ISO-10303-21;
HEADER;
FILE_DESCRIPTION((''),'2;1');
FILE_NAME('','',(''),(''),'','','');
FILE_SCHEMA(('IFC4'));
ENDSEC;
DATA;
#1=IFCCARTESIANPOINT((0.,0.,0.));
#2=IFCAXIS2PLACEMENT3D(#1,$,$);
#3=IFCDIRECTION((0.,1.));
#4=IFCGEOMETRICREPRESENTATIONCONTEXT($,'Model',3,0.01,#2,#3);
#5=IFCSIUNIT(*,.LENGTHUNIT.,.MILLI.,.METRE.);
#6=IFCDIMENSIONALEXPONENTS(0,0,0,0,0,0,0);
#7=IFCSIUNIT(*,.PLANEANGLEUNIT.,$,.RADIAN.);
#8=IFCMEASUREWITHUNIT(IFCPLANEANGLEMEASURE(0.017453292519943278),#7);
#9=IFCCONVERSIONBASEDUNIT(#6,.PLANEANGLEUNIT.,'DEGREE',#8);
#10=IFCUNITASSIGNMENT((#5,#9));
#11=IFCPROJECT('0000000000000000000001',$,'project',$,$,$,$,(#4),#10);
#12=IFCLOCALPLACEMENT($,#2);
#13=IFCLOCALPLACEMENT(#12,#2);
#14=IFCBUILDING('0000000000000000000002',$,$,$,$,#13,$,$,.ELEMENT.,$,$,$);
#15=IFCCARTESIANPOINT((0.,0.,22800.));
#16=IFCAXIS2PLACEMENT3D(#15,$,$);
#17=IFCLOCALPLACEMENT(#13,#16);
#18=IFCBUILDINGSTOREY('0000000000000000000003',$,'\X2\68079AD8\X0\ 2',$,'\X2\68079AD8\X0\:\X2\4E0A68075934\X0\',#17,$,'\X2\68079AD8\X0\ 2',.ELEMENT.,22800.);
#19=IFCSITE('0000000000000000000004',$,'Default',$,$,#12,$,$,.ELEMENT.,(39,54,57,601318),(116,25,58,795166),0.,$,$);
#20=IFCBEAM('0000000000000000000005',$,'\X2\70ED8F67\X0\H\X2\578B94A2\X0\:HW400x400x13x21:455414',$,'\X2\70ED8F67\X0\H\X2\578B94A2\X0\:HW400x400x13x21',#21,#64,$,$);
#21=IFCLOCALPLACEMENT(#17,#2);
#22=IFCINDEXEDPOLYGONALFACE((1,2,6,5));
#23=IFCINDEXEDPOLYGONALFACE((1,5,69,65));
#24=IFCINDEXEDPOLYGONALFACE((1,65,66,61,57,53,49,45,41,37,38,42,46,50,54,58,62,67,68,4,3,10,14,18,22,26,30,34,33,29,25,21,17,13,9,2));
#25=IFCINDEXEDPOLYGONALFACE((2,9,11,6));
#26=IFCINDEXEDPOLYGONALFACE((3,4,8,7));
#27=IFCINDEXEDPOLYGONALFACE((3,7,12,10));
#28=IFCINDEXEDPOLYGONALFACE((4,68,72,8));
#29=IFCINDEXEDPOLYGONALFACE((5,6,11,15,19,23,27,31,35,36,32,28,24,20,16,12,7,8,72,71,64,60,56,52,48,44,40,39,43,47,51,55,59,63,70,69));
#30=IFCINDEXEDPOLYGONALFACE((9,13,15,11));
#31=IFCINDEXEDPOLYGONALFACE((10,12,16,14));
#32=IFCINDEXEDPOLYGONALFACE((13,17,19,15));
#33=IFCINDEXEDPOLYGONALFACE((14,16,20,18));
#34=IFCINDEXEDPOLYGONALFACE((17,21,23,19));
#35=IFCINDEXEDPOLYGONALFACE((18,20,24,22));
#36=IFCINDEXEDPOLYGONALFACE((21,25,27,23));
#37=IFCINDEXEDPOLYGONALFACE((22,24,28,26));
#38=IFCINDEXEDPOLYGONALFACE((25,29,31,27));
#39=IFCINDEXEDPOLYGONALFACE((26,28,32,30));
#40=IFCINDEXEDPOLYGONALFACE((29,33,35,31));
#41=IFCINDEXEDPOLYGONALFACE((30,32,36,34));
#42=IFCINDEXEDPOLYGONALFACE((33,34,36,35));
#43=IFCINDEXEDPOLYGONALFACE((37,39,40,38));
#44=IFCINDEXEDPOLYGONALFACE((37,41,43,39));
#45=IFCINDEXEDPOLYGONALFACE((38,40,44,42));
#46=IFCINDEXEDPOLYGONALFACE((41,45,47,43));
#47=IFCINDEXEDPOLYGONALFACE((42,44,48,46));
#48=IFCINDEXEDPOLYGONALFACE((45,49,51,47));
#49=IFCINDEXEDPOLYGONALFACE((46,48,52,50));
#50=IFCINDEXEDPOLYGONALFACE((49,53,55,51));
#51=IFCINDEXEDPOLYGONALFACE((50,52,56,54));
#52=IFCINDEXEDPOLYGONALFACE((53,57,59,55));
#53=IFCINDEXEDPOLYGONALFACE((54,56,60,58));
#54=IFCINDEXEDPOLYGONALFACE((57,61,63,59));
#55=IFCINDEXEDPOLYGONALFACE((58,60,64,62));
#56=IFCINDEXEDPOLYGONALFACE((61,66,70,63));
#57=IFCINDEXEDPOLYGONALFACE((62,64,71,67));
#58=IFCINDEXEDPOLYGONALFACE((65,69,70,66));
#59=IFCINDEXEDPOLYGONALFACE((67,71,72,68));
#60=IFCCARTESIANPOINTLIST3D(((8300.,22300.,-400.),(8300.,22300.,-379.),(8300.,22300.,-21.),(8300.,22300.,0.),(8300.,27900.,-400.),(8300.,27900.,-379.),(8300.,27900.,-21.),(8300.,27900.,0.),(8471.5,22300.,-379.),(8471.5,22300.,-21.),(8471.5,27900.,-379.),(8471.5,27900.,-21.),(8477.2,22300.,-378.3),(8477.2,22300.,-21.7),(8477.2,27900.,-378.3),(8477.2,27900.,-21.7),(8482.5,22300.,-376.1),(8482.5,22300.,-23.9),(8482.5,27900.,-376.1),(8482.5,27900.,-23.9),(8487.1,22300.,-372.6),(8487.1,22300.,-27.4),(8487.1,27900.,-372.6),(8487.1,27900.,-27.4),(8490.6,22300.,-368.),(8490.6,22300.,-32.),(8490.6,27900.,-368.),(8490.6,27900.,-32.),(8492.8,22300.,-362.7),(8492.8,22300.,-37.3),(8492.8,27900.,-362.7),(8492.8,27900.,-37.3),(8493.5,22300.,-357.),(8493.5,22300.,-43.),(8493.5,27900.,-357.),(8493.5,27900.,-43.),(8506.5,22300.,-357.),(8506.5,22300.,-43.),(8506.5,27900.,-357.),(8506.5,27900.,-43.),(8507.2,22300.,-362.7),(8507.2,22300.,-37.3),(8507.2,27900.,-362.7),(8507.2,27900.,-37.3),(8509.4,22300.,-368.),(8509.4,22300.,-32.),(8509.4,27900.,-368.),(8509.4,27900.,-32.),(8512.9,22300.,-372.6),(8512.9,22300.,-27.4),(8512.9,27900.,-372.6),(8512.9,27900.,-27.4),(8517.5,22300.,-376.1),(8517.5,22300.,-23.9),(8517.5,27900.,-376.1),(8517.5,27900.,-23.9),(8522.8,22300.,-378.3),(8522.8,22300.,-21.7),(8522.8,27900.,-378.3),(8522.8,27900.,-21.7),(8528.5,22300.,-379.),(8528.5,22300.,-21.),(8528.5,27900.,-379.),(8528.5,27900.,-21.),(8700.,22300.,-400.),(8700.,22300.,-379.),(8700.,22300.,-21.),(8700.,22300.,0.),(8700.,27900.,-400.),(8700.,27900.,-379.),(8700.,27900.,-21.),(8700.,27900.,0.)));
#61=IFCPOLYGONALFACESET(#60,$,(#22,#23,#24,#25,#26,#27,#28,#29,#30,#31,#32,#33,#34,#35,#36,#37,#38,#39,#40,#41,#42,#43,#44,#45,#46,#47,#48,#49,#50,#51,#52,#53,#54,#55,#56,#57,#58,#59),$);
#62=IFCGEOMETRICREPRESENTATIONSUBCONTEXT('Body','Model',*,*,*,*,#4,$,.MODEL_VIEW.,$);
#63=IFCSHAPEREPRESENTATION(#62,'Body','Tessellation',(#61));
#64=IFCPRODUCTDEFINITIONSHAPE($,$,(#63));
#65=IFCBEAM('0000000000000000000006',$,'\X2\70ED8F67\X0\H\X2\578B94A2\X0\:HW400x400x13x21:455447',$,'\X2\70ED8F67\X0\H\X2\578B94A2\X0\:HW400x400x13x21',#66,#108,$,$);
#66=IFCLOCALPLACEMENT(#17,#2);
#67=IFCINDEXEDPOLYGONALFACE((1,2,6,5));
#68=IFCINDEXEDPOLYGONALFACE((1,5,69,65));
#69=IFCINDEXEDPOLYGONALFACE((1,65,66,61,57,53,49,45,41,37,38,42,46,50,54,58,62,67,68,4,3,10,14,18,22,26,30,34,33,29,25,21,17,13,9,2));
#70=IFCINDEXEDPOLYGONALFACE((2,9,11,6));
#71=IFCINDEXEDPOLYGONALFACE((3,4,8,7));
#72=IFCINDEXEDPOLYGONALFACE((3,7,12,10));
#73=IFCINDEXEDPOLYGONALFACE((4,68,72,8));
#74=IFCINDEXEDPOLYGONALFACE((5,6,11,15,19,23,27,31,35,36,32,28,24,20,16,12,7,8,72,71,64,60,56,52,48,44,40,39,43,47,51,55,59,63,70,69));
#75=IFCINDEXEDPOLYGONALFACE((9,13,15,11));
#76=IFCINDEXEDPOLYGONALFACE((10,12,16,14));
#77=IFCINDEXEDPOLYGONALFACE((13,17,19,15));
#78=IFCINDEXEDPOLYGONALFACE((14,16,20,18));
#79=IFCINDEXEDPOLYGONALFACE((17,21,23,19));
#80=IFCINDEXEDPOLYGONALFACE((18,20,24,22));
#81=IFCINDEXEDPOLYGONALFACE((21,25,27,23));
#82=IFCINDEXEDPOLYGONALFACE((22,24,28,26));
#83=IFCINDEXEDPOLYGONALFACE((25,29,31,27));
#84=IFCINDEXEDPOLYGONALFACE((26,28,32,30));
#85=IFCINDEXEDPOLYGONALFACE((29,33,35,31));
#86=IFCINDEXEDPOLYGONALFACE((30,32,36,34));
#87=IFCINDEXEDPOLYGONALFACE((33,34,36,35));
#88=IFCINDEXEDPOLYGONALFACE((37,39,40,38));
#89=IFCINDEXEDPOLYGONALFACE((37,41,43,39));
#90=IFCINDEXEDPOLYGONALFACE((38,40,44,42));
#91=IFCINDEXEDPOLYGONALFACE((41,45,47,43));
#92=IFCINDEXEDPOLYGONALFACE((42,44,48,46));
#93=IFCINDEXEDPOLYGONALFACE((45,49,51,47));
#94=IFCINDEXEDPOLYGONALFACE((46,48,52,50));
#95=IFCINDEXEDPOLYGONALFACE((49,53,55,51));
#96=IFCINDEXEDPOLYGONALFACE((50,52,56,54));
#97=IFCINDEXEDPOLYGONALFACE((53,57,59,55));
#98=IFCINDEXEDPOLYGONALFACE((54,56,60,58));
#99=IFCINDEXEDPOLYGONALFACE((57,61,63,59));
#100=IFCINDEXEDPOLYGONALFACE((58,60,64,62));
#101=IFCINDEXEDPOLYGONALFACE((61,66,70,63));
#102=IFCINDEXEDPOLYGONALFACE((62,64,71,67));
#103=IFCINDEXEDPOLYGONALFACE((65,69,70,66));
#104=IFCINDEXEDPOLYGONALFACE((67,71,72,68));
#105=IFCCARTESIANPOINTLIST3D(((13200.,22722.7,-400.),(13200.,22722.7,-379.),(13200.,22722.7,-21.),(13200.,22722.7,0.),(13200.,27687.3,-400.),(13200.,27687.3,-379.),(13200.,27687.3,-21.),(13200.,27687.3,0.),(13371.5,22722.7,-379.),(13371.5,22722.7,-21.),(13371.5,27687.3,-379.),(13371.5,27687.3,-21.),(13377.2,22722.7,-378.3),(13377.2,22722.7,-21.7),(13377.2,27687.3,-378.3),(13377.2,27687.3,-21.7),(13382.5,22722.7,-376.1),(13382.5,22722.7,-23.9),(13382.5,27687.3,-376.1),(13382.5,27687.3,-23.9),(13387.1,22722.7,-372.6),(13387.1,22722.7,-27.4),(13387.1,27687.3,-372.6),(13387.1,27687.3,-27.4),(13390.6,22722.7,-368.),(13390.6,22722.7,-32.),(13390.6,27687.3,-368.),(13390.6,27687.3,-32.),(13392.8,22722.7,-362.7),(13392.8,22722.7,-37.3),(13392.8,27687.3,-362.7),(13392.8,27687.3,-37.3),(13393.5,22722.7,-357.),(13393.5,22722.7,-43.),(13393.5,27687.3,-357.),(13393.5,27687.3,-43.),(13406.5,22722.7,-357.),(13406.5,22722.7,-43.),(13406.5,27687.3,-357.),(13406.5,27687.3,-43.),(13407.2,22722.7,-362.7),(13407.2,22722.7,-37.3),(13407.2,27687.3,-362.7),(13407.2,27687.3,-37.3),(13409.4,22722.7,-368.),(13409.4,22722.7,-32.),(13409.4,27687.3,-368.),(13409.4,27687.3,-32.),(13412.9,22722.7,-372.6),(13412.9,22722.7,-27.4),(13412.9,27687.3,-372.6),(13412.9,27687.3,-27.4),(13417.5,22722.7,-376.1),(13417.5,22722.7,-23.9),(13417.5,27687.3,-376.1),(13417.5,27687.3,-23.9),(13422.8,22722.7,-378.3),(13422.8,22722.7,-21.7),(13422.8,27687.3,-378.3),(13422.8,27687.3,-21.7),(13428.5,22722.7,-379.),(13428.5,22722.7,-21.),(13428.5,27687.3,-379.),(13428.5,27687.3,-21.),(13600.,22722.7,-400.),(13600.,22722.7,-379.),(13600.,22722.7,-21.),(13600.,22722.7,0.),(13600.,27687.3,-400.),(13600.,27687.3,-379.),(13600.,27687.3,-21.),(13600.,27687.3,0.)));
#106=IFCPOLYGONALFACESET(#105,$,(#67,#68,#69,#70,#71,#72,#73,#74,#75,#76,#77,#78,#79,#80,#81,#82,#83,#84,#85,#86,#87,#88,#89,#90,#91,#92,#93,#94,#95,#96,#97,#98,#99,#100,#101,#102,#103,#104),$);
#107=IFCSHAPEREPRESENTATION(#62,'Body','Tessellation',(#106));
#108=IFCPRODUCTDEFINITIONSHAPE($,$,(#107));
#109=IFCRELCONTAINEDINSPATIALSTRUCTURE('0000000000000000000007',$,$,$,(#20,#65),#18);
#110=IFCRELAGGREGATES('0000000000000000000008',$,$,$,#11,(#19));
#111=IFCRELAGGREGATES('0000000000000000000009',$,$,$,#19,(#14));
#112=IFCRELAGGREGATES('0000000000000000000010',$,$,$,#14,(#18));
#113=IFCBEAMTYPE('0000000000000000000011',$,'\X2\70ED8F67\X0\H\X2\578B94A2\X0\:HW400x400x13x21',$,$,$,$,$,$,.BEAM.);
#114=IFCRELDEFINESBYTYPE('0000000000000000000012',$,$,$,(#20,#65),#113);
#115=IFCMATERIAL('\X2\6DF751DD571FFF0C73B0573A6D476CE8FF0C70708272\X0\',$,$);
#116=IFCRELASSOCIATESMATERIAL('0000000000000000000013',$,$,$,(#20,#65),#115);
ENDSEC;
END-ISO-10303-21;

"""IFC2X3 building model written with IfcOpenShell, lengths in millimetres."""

from ifc_helpers import new_model, entity, si_unit, converted_unit, direction, frame, frame_2d, origin, place, context, subcontext, project, spatial, i_section, extrude, material, type_object, element, save


model = new_model("IFC2X3")

# Units and contexts
model_context = context("Model", 3, precision=0.01, world=origin(), true_north=direction((0.0, 1.0)))
body_context = subcontext(model_context, "Body", "Model", "MODEL_VIEW")
ifc_project = project(units=[si_unit("LENGTHUNIT", "METRE", prefix="MILLI"), converted_unit("PLANEANGLEUNIT", "DEGREE", entity("IfcPlaneAngleMeasure", 0.017453292519943278), si_unit("PLANEANGLEUNIT", "RADIAN"), dimensions=[0, 0, 0, 0, 0, 0, 0])], contexts=[model_context])

# Site, building, storey
site_placement = place(None, origin())
site = spatial("IfcSite", under=ifc_project, at=site_placement, Name="Default", CompositionType="ELEMENT", RefLatitude=(39, 54, 57, 601318), RefLongitude=(116, 25, 58, 795166), RefElevation=0.0)
building_placement = place(site_placement, origin())
building = spatial("IfcBuilding", under=site, at=building_placement, CompositionType="ELEMENT")
storey_placement = place(building_placement, frame((0.0, 0.0, 22800.0)))
storey = spatial("IfcBuildingStorey", under=building, at=storey_placement, Name="标高 2", ObjectType="标高:上标头", LongName="标高 2", CompositionType="ELEMENT", Elevation=22800.0)

# Beams
ifc_material = material(Name="混凝土，现场浇注，灰色")
beam_type = type_object("IfcBeamType", Name="热轧H型钢:HW400x400x13x21", PredefinedType="BEAM")
beam_1_placement = place(storey_placement, frame((8500.0, 27900.0, 0.0), z_axis=(0.0, 0.0, 1.0), x_axis=(0.0, -1.0, 0.0)))
element("IfcBeam", 1, at=beam_1_placement, inside=storey, type_object=beam_type, material=ifc_material, Name="热轧H型钢:HW400x400x13x21:455414", ObjectType="热轧H型钢:HW400x400x13x21", context=body_context, shape_type="SweptSolid", body=[
    extrude(i_section(OverallWidth=400.0, OverallDepth=400.0, WebThickness=13.0, FlangeThickness=21.0, FilletRadius=22.0, at=frame_2d((0.0, 0.0), x_axis=(0.0, 1.0))), frame((0.0, 0.0, -200.0), z_axis=(1.0, 0.0, 0.0), x_axis=(0.0, 0.0, -1.0)), (0.0, 0.0, 1.0), 5600.0),
])
beam_2_placement = place(storey_placement, frame((13400.0, 27900.0, 0.0), z_axis=(0.0, 0.0, 1.0), x_axis=(0.0, -1.0, 0.0)))
element("IfcBeam", 2, at=beam_2_placement, inside=storey, type_object=beam_type, material=ifc_material, Name="热轧H型钢:HW400x400x13x21:455447", ObjectType="热轧H型钢:HW400x400x13x21", context=body_context, shape_type="SweptSolid", body=[
    extrude(i_section(OverallWidth=400.0, OverallDepth=400.0, WebThickness=13.0, FlangeThickness=21.0, FilletRadius=22.0, at=frame_2d((0.0, 0.0), x_axis=(0.0, 1.0))), frame((212.7, 0.0, -200.0), z_axis=(1.0, 0.0, 0.0), x_axis=(0.0, 0.0, -1.0)), (0.0, 0.0, 1.0), 4964.6),
])

save(model, "model.ifc")
